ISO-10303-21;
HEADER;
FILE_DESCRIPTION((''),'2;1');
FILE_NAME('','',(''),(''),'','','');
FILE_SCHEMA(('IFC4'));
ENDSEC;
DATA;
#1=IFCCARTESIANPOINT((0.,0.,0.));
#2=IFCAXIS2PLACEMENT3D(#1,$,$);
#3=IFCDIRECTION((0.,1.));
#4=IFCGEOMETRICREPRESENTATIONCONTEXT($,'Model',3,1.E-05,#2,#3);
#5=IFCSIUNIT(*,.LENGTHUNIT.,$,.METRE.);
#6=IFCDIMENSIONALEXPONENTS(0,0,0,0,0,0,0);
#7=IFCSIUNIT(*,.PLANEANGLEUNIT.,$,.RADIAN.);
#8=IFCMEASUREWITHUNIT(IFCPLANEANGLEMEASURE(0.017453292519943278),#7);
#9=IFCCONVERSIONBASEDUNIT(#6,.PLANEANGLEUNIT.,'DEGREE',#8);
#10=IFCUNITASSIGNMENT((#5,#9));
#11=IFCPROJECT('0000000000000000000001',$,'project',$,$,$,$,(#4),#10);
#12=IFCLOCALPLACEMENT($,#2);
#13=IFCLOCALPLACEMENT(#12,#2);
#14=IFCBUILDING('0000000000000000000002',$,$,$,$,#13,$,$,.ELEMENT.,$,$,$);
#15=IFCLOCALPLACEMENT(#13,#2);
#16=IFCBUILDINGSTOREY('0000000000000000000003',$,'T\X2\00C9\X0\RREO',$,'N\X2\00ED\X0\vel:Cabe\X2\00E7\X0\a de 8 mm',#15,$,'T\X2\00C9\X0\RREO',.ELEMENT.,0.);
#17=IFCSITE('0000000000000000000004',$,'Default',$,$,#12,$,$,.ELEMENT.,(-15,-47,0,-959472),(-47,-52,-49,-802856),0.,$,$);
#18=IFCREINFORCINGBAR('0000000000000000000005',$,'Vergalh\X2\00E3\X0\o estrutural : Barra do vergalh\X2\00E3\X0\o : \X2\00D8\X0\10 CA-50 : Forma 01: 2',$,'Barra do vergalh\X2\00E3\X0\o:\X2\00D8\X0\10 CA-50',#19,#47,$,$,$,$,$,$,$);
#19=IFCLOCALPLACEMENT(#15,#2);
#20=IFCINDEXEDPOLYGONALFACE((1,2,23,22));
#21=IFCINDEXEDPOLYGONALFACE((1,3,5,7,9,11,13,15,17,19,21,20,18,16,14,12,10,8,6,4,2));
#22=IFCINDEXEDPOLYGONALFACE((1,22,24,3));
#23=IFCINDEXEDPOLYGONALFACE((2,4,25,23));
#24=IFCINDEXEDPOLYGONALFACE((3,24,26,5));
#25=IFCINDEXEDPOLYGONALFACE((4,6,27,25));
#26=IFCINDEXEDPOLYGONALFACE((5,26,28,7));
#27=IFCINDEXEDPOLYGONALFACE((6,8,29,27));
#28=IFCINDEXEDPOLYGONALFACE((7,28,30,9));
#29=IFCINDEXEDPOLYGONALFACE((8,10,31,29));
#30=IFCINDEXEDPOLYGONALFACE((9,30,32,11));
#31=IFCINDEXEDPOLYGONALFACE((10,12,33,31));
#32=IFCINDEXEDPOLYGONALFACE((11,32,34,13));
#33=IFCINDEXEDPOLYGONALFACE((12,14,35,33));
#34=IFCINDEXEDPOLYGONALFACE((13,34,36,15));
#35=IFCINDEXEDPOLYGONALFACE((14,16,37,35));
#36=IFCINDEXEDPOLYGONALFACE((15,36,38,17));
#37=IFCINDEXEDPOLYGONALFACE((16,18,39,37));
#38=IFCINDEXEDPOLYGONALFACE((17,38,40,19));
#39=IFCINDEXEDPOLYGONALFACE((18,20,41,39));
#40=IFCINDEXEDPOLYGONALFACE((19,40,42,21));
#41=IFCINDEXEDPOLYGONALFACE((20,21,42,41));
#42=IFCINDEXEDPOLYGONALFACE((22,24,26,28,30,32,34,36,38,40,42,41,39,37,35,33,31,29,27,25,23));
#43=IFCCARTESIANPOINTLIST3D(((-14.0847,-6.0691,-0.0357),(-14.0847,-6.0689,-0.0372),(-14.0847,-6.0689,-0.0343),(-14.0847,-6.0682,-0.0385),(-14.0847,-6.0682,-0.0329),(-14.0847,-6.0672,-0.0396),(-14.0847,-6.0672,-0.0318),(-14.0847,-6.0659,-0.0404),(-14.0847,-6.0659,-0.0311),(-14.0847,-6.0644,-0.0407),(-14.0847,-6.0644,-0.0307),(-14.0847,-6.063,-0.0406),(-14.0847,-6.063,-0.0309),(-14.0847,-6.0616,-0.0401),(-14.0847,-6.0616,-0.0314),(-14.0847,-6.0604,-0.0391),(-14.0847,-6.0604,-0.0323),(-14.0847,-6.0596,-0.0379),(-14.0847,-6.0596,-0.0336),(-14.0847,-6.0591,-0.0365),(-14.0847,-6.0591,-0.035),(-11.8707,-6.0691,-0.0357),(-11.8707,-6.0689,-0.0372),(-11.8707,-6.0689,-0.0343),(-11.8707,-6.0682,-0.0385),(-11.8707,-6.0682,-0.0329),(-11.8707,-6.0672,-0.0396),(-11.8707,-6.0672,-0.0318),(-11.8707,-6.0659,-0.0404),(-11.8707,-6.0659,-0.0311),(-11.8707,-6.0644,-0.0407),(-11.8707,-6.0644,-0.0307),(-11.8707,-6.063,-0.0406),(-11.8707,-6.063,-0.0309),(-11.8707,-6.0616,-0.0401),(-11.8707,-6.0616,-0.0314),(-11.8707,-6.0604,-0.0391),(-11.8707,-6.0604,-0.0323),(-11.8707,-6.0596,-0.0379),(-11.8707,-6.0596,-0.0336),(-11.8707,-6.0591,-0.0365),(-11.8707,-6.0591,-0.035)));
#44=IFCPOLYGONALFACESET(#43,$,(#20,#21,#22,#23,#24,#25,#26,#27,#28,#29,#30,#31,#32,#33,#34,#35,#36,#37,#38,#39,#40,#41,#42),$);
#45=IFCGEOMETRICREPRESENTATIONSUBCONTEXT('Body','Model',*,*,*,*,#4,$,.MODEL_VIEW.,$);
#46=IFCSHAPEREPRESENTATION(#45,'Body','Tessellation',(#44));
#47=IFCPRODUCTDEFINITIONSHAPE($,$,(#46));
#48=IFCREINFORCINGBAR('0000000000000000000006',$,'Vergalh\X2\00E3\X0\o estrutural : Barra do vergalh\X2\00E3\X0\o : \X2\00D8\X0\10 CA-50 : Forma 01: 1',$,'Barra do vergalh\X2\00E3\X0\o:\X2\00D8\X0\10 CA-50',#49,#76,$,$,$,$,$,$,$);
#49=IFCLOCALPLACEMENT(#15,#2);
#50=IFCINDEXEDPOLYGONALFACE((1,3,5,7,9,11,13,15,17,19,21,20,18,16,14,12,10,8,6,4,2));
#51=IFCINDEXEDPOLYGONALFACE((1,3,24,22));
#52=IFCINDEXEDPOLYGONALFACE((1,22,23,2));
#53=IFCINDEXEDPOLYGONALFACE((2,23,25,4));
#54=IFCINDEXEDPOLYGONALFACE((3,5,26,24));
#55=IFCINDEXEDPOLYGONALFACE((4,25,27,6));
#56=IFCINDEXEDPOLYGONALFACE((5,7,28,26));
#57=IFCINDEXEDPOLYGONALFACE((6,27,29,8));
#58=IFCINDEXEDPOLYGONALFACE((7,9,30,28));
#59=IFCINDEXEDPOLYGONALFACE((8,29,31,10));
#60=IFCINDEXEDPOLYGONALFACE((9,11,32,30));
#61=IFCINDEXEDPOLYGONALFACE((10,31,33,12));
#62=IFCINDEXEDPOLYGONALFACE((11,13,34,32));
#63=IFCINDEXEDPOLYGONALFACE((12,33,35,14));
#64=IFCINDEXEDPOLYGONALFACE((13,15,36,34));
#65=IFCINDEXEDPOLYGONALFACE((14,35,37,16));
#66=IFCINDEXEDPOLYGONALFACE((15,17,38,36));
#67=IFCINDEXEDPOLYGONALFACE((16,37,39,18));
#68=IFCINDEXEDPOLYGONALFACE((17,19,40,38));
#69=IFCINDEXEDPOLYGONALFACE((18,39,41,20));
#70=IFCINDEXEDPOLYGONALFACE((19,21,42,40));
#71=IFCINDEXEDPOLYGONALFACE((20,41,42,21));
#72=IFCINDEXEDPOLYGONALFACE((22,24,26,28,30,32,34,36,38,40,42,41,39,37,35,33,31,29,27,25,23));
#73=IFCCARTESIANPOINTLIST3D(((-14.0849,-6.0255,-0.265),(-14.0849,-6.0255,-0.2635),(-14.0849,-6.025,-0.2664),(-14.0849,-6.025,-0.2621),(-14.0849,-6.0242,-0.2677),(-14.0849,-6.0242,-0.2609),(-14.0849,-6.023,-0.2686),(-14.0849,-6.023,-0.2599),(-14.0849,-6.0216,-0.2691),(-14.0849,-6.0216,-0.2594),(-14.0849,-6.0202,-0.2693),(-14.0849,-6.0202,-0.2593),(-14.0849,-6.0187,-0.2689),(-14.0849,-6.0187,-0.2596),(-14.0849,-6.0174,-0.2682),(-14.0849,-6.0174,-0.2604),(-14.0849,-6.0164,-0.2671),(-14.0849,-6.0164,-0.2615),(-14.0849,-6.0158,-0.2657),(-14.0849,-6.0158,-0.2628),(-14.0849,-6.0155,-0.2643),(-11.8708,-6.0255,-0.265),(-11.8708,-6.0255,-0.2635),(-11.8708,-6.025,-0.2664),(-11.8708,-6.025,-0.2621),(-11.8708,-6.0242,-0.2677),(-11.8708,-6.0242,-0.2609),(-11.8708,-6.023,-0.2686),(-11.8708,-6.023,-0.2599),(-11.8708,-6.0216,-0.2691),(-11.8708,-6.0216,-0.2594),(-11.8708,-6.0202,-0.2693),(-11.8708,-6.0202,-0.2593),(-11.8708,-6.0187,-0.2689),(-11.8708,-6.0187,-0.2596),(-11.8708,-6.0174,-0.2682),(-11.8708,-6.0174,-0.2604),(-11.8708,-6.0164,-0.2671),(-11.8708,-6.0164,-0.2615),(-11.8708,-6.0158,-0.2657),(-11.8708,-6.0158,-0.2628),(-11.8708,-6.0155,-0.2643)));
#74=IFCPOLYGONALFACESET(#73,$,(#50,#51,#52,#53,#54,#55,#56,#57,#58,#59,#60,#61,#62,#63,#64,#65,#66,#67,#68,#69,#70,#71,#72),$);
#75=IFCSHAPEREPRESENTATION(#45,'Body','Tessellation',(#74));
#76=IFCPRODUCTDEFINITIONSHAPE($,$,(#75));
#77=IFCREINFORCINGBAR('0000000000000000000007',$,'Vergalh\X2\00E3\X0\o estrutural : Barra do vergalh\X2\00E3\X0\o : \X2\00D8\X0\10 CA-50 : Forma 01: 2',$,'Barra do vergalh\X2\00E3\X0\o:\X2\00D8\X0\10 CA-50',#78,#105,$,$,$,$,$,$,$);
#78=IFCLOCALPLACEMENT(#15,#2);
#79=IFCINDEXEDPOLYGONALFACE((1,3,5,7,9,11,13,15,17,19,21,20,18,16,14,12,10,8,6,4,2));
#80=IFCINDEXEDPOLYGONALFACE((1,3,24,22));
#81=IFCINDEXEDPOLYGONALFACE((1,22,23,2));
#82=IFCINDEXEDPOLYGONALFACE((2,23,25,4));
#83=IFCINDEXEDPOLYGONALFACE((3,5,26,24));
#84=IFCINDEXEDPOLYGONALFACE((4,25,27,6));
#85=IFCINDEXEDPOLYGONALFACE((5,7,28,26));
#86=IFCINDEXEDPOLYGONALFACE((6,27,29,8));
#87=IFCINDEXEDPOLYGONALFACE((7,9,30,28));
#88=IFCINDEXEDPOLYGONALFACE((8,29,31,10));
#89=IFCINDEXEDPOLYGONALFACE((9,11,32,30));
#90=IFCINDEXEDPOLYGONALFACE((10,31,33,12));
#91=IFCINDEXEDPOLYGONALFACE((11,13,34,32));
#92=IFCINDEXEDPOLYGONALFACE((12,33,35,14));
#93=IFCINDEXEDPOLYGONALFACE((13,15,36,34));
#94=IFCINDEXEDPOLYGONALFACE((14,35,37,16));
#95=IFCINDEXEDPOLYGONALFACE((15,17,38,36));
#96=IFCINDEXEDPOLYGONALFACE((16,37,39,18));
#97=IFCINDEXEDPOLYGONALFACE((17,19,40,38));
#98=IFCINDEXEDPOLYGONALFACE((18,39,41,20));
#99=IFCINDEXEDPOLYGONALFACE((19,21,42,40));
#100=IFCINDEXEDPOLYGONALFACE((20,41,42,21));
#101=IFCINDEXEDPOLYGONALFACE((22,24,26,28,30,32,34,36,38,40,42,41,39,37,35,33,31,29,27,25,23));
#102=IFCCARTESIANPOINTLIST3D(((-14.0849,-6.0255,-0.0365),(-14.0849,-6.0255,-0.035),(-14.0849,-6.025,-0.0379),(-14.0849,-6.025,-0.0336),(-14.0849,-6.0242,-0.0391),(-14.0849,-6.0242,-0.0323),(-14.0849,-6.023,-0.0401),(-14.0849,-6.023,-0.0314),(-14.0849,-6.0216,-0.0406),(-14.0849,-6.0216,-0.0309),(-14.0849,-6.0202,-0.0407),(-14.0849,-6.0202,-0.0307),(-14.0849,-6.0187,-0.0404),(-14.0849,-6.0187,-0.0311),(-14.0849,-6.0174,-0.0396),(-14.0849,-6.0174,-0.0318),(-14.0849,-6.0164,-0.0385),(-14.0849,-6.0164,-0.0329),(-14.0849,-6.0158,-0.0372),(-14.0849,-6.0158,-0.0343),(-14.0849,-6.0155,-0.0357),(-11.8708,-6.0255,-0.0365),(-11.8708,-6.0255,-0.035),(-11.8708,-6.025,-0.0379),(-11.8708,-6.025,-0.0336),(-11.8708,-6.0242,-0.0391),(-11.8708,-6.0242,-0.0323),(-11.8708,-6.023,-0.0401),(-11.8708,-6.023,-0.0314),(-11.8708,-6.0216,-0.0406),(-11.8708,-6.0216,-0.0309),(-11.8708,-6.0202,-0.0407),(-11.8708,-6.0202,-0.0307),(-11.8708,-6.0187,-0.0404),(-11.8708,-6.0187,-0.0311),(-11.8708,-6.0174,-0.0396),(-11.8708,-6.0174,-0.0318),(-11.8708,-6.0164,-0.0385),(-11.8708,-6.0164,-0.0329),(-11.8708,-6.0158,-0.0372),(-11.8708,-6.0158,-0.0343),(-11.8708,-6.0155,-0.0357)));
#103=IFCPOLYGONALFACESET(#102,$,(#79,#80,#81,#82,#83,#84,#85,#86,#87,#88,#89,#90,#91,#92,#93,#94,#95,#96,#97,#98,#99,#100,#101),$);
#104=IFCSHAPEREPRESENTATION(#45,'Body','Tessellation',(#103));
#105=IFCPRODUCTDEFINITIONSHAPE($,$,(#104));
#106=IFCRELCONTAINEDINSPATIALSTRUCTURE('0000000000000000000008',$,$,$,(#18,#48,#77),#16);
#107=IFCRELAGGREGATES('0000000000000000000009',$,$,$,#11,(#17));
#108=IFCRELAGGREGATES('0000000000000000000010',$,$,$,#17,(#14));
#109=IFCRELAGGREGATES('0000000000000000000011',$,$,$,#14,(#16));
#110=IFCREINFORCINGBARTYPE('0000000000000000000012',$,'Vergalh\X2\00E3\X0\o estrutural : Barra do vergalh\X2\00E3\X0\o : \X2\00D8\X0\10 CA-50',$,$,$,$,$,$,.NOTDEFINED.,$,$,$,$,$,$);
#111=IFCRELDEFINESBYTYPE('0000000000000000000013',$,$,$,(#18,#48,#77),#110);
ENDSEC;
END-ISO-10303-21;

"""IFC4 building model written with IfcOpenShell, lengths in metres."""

from ifc_helpers import new_model, entity, si_unit, converted_unit, direction, origin, place, context, subcontext, project, spatial, type_object, element, save


model = new_model("IFC4")

# Units and contexts
model_context = context("Model", 3, precision=1e-05, world=origin(), true_north=direction((0.0, 1.0)))
body_context = subcontext(model_context, "Body", "Model", "MODEL_VIEW")
ifc_project = project(units=[si_unit("LENGTHUNIT", "METRE"), converted_unit("PLANEANGLEUNIT", "DEGREE", entity("IfcPlaneAngleMeasure", 0.017453292519943278), si_unit("PLANEANGLEUNIT", "RADIAN"), dimensions=[0, 0, 0, 0, 0, 0, 0])], contexts=[model_context])

# Site, building, storey
site_placement = place(None, origin())
site = spatial("IfcSite", under=ifc_project, at=site_placement, Name="Default", CompositionType="ELEMENT", RefLatitude=(-15, -47, 0, -959472), RefLongitude=(-47, -52, -49, -802856), RefElevation=0.0)
building_placement = place(site_placement, origin())
building = spatial("IfcBuilding", under=site, at=building_placement, CompositionType="ELEMENT")
storey_placement = place(building_placement, origin())
storey = spatial("IfcBuildingStorey", under=building, at=storey_placement, Name="TÉRREO", ObjectType="Nível:Cabeça de 8 mm", LongName="TÉRREO", CompositionType="ELEMENT", Elevation=0.0)

# Reinforcing bars
reinforcing_bar_type_1 = type_object("IfcReinforcingBarType", Name="Vergalhão estrutural : Barra do vergalhão : Ø10 CA-50", PredefinedType="NOTDEFINED")
reinforcing_bar_1_placement = place(storey_placement, origin())
element("IfcReinforcingBar", 1, at=reinforcing_bar_1_placement, inside=storey, type_object=reinforcing_bar_type_1, Name="Vergalhão estrutural : Barra do vergalhão : Ø10 CA-50 : Forma 01: 2", ObjectType="Barra do vergalhão:Ø10 CA-50", context=body_context, shape_type="AdvancedSweptSolid", body=[
    entity("IfcSweptDiskSolid", entity("IfcIndexedPolyCurve", entity("IfcCartesianPointList3D", [[-11.8707, -6.0641, -0.0357], [-14.0847, -6.0641, -0.0357]]), None, False), 0.005, None, 0.0, 1.0),
])
reinforcing_bar_2_placement = place(storey_placement, origin())
element("IfcReinforcingBar", 2, at=reinforcing_bar_2_placement, inside=storey, type_object=reinforcing_bar_type_1, Name="Vergalhão estrutural : Barra do vergalhão : Ø10 CA-50 : Forma 01: 1", ObjectType="Barra do vergalhão:Ø10 CA-50", context=body_context, shape_type="AdvancedSweptSolid", body=[
    entity("IfcSweptDiskSolid", entity("IfcIndexedPolyCurve", entity("IfcCartesianPointList3D", [[-14.0849, -6.0205, -0.2643], [-11.8708, -6.0205, -0.2643]]), None, False), 0.005, None, 0.0, 1.0),
])
reinforcing_bar_3_placement = place(storey_placement, origin())
element("IfcReinforcingBar", 3, at=reinforcing_bar_3_placement, inside=storey, type_object=reinforcing_bar_type_1, Name="Vergalhão estrutural : Barra do vergalhão : Ø10 CA-50 : Forma 01: 2", ObjectType="Barra do vergalhão:Ø10 CA-50", context=body_context, shape_type="AdvancedSweptSolid", body=[
    entity("IfcSweptDiskSolid", entity("IfcIndexedPolyCurve", entity("IfcCartesianPointList3D", [[-14.0849, -6.0205, -0.0357], [-11.8708, -6.0205, -0.0357]]), None, False), 0.005, None, 0.0, 1.0),
])

save(model, "model.ifc")
